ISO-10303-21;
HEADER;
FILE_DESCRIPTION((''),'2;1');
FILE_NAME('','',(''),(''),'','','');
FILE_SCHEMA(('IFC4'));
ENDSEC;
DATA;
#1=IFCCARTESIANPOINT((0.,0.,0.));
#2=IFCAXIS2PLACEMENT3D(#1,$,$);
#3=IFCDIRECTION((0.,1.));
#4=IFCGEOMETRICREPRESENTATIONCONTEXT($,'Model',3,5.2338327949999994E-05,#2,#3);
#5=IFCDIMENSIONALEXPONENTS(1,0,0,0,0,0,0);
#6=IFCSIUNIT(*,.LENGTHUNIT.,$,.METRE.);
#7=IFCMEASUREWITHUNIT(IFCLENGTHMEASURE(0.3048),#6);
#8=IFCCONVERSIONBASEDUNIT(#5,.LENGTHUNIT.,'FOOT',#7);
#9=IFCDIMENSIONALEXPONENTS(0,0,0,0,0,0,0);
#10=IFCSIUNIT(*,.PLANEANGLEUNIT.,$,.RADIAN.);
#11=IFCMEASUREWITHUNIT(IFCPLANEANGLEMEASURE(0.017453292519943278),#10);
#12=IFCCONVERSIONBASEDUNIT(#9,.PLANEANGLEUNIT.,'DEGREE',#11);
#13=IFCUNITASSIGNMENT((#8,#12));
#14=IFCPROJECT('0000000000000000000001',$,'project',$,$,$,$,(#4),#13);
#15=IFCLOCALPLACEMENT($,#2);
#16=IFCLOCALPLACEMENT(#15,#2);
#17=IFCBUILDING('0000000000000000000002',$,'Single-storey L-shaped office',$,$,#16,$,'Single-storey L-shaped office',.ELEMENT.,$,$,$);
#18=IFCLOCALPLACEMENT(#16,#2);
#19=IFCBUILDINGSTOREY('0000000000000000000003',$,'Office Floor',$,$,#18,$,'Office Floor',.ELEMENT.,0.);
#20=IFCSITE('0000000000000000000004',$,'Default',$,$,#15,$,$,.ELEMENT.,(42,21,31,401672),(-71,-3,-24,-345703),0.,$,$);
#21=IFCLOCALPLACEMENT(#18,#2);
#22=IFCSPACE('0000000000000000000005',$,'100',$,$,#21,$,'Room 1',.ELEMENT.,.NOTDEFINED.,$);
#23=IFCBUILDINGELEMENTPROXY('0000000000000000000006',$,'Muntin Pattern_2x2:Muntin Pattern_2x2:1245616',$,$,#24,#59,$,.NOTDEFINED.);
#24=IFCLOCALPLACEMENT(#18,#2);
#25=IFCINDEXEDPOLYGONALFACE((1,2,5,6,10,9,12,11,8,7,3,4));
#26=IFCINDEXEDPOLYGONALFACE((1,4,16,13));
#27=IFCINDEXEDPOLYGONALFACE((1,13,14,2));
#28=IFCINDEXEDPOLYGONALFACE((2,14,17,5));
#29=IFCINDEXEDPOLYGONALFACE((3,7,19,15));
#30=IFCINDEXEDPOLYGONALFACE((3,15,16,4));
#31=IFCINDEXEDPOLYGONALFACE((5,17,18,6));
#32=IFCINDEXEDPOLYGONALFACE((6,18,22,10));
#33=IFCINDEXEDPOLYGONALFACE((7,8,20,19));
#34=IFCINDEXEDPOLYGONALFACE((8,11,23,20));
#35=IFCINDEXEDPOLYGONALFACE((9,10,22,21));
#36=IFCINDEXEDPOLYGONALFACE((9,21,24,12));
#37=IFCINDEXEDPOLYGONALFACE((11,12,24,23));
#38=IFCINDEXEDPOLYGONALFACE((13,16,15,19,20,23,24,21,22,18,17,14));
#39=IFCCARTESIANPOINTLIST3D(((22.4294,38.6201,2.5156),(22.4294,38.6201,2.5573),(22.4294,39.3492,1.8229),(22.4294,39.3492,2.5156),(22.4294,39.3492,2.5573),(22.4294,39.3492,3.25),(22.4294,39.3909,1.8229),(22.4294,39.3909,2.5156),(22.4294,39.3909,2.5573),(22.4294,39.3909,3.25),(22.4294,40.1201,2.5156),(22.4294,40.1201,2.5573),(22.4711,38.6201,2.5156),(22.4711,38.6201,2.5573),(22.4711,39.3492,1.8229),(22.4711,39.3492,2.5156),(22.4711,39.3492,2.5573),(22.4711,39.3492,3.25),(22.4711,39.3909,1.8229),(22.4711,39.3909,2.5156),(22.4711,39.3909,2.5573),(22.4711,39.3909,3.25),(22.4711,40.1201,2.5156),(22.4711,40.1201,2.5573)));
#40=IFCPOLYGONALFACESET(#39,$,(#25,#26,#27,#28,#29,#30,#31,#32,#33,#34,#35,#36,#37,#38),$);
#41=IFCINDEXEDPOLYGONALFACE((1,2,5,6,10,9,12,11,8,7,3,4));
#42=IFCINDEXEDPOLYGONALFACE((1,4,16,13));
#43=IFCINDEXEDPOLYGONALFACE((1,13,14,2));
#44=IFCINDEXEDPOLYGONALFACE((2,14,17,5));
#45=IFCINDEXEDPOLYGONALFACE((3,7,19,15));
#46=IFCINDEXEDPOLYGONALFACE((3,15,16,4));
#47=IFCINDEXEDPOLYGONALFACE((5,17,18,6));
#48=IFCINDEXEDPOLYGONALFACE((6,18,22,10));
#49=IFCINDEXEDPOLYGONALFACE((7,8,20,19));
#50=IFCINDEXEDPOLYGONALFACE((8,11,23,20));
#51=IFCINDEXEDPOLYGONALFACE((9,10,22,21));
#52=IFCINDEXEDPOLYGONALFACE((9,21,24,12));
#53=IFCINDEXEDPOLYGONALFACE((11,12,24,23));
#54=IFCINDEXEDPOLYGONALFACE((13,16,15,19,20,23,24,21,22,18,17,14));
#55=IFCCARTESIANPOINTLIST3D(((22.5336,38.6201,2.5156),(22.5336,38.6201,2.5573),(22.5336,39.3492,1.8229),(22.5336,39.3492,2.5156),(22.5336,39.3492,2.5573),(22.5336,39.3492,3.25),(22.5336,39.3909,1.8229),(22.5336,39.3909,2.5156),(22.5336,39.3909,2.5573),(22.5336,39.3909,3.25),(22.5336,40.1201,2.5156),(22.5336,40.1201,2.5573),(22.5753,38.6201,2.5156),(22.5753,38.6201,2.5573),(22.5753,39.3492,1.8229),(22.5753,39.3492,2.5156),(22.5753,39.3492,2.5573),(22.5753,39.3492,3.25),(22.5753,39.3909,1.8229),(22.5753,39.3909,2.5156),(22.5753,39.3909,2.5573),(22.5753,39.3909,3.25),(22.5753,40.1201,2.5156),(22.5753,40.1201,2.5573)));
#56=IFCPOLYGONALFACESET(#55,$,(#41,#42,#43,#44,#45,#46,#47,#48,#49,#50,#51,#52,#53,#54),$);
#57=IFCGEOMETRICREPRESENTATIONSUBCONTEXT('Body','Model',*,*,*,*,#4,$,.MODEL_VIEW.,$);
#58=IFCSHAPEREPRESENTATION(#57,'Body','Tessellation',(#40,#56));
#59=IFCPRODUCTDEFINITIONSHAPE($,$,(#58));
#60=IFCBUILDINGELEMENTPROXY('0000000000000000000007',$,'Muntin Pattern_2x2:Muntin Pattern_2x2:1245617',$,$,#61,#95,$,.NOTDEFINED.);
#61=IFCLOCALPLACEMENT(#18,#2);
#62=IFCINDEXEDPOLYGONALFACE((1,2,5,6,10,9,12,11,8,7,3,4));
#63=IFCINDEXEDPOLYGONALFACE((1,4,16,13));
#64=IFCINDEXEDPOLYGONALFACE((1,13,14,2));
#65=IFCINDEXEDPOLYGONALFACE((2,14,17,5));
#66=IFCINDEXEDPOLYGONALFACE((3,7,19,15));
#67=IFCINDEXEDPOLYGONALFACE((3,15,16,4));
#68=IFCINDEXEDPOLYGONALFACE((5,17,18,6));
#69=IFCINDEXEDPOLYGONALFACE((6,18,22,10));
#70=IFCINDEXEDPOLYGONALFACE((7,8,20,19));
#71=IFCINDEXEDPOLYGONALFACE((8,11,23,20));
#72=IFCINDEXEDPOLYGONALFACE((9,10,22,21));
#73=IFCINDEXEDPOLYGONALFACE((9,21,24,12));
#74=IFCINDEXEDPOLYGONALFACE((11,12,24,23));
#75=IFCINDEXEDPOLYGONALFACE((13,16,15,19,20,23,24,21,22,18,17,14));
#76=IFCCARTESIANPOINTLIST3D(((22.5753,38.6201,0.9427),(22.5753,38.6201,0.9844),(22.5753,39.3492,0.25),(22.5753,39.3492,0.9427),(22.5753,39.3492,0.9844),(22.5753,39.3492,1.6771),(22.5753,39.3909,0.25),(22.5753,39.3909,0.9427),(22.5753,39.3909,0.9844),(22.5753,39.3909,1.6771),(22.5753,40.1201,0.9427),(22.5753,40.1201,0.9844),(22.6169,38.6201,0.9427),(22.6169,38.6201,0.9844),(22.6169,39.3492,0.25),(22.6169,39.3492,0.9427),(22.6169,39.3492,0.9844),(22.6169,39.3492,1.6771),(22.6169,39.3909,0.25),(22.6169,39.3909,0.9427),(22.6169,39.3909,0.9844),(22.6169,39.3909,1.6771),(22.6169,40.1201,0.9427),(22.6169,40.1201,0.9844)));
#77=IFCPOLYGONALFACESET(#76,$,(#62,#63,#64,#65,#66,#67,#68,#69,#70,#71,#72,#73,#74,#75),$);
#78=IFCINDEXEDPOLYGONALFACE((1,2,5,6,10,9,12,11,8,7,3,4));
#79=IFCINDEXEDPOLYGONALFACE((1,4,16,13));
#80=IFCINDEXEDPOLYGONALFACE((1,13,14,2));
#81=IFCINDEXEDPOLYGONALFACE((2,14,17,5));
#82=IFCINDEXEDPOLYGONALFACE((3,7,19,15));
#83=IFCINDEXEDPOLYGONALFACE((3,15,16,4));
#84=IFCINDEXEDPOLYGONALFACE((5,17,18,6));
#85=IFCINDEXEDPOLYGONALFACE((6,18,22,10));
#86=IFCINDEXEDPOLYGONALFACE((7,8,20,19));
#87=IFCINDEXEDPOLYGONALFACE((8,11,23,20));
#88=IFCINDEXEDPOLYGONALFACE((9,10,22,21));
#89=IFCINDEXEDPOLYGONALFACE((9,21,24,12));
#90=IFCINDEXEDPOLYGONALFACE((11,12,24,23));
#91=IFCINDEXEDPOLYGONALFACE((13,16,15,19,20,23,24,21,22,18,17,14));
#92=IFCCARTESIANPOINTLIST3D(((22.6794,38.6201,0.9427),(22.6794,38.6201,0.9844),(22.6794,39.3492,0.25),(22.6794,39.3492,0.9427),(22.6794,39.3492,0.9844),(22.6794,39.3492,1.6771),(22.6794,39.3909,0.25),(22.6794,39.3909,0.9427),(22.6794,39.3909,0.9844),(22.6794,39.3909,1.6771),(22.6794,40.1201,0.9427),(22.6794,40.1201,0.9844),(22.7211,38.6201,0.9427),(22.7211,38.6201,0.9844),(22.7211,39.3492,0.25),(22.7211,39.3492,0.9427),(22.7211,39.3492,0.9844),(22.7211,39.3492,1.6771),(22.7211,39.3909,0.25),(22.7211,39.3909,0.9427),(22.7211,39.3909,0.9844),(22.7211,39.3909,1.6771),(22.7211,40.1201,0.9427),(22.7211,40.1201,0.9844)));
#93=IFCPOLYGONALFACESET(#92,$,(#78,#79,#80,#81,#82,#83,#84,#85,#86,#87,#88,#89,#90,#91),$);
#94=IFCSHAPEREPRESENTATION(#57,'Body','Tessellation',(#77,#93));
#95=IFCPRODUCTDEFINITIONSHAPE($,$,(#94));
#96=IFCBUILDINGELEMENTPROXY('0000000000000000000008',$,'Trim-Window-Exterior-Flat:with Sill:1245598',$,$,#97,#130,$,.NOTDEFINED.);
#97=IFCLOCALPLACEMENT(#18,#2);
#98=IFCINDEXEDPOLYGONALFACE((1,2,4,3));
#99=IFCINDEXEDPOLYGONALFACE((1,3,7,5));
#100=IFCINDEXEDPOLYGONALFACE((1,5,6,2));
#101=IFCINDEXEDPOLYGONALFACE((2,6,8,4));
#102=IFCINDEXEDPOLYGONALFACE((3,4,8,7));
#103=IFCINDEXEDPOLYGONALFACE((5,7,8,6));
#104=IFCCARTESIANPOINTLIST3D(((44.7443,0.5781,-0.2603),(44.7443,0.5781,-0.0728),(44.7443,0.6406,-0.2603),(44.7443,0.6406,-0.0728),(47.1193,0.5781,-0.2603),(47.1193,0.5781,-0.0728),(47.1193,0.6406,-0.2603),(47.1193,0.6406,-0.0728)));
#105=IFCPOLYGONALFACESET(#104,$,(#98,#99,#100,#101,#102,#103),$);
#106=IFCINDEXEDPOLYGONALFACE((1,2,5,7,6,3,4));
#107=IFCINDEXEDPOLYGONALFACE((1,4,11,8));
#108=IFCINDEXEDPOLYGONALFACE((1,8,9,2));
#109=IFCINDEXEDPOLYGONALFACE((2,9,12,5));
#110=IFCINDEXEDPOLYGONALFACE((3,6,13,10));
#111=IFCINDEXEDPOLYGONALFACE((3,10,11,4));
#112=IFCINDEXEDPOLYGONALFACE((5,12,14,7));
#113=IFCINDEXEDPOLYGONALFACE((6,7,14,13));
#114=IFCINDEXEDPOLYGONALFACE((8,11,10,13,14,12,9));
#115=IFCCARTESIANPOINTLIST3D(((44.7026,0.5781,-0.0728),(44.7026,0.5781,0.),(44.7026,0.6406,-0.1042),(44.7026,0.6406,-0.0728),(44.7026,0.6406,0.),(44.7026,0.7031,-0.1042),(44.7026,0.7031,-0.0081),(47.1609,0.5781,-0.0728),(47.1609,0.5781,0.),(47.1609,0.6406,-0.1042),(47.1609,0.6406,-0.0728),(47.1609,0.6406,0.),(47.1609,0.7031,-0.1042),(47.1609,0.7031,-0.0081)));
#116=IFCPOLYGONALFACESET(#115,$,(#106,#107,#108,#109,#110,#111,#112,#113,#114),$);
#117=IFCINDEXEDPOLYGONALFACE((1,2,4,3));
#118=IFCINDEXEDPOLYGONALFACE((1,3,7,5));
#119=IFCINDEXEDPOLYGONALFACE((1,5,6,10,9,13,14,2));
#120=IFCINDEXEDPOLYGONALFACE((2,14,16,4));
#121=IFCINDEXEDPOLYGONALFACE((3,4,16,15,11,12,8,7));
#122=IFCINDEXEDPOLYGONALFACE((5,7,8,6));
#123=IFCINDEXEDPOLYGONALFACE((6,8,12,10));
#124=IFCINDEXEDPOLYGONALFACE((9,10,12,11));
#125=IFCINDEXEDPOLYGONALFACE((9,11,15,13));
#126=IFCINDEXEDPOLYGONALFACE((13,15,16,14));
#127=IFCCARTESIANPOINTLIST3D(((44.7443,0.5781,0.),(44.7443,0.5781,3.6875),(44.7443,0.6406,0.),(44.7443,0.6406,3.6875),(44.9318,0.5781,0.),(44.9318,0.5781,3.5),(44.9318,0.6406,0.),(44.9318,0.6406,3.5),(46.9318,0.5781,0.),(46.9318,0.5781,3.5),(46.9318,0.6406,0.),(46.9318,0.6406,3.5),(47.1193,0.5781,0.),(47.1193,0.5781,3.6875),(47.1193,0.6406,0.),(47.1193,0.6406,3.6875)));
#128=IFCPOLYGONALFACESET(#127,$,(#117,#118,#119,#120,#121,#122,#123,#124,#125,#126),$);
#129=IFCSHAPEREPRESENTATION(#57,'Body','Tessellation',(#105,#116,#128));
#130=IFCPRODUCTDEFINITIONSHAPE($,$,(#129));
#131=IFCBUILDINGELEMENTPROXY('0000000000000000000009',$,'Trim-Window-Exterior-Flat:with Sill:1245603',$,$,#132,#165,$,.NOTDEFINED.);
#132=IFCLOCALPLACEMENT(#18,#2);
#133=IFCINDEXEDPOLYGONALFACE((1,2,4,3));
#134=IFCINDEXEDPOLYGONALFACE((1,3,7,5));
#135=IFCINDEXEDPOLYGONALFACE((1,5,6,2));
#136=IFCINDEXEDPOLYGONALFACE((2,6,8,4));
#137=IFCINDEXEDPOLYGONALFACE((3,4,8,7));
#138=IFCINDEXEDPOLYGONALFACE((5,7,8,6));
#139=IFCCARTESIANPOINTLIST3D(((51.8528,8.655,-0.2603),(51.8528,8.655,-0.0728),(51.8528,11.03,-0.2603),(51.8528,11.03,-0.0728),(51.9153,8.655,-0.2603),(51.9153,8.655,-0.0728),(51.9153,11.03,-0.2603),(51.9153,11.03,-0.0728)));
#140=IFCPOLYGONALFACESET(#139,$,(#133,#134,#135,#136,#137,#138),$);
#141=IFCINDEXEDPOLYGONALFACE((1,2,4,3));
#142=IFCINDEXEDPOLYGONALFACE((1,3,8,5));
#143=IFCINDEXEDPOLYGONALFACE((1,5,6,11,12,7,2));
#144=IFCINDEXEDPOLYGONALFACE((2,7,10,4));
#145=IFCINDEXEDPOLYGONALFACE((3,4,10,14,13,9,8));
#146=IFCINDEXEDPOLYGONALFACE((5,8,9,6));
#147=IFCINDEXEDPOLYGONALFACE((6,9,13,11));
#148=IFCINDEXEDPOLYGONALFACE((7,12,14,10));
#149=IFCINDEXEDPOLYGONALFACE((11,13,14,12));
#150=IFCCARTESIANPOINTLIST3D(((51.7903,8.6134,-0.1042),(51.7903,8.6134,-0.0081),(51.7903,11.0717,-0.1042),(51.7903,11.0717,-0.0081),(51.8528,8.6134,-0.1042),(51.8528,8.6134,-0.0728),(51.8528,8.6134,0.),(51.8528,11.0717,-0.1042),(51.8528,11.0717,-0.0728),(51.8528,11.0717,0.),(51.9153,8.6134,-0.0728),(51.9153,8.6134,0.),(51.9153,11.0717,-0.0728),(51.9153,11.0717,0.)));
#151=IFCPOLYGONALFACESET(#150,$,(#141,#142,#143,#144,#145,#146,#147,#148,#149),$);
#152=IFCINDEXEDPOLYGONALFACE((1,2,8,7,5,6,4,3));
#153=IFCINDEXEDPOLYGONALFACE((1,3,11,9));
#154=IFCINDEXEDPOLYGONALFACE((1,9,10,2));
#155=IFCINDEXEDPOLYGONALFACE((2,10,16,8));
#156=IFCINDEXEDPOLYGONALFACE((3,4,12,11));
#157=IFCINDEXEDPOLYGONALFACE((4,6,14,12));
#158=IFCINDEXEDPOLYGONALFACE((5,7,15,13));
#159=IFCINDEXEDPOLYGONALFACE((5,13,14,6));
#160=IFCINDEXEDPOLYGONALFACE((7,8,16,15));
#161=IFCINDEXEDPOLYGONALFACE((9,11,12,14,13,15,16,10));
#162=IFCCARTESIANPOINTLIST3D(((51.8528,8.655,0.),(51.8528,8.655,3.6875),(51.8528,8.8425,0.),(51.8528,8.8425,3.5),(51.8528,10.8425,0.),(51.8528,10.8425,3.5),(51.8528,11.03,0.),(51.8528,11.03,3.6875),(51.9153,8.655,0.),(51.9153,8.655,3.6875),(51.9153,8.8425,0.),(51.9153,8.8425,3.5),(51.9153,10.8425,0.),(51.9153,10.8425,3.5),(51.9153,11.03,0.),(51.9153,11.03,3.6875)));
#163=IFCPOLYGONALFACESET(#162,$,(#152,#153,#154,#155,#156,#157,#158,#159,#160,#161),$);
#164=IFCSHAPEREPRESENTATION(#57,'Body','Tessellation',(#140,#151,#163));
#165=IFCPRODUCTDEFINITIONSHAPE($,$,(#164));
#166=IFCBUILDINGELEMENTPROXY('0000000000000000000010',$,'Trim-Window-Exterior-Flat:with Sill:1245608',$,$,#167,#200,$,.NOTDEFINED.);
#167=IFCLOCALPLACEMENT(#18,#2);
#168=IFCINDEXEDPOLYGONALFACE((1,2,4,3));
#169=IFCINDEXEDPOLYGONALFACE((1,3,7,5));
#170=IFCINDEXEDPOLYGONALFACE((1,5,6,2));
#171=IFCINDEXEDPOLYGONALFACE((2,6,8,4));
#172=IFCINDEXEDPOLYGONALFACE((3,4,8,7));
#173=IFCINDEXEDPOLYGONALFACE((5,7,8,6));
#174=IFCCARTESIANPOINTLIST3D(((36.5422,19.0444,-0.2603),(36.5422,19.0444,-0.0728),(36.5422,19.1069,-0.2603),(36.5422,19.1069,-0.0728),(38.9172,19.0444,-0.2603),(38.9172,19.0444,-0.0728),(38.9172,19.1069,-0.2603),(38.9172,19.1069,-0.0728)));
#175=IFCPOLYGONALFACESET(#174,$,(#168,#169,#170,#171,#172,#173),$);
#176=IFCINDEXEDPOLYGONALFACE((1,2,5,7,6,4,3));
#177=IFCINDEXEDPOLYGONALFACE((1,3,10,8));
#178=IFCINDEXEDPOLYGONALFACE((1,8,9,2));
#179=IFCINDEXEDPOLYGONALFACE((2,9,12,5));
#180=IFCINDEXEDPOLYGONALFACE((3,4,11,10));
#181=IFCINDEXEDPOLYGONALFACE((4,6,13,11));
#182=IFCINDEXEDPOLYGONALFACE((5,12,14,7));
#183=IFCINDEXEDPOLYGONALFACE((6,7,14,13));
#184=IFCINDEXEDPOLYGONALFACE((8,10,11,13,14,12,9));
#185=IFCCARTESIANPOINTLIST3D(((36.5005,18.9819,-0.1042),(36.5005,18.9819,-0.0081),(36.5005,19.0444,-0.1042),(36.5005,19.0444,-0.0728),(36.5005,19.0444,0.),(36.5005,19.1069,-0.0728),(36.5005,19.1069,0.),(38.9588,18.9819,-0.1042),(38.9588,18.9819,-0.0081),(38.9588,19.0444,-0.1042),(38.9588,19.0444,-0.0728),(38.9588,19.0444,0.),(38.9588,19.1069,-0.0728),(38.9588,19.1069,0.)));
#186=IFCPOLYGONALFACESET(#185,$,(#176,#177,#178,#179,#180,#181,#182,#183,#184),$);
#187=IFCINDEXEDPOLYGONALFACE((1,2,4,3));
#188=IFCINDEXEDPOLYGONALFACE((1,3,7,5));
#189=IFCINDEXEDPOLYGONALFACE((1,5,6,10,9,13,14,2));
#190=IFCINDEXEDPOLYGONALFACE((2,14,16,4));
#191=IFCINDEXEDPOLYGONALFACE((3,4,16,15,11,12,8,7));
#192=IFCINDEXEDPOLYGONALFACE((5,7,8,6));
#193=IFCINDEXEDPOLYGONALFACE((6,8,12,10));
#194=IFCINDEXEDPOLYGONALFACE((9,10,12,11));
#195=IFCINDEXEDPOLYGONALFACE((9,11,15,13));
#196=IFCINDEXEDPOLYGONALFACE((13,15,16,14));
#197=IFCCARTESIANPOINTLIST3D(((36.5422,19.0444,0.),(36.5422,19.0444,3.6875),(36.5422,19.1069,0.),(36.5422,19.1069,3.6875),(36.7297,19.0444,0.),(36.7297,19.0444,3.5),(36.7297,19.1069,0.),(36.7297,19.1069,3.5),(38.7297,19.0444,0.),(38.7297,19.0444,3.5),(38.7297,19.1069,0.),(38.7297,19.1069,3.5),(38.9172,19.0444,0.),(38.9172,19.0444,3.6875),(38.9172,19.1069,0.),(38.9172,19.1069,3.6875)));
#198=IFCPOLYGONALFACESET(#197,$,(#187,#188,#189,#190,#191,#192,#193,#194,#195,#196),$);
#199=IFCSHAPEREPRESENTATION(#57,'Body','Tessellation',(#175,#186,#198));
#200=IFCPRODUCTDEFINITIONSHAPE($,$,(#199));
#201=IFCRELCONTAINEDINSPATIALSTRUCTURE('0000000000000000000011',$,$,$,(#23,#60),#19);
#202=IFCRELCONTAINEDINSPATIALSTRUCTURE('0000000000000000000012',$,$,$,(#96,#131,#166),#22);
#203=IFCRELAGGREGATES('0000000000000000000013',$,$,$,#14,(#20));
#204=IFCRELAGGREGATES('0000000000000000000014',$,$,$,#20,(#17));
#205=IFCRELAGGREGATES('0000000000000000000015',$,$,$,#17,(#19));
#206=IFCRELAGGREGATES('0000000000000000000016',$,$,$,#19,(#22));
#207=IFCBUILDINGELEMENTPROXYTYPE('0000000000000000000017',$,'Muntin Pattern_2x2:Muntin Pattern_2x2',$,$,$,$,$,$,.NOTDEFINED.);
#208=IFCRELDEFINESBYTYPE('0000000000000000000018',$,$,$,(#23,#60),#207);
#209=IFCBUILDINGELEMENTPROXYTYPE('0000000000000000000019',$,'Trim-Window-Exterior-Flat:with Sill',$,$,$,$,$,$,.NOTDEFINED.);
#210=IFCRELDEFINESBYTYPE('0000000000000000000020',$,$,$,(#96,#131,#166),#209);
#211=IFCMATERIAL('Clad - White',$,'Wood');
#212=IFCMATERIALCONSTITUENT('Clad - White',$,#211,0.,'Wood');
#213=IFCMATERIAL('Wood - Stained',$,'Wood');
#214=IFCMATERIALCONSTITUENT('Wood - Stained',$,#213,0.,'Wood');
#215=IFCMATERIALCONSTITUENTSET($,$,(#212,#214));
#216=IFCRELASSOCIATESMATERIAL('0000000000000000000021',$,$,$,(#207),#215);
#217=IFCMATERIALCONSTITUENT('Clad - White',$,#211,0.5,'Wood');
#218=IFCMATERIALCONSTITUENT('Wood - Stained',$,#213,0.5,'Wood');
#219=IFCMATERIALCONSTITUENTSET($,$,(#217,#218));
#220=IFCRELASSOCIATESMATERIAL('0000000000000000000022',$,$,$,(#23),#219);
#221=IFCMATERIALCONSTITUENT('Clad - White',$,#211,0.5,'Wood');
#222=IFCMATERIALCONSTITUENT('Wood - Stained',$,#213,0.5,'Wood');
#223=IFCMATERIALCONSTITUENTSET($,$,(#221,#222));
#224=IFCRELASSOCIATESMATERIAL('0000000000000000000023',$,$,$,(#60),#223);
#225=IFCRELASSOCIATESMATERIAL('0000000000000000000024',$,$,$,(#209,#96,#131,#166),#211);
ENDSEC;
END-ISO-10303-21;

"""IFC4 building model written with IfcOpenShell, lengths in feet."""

from ifc_helpers import new_model, entity, si_unit, converted_unit, direction, frame, origin, place, context, subcontext, project, spatial, indexed_curve, outline, extrude, source, transform, mapped, material, constituent, constituent_set, type_object, type_shapes, element, save


model = new_model("IFC4")

# Units and contexts
model_context = context("Model", 3, precision=5.2338327949999994e-05, world=origin(), true_north=direction((0.0, 1.0)))
body_context = subcontext(model_context, "Body", "Model", "MODEL_VIEW")
ifc_project = project(units=[converted_unit("LENGTHUNIT", "FOOT", entity("IfcLengthMeasure", 0.3048), si_unit("LENGTHUNIT", "METRE"), dimensions=[1, 0, 0, 0, 0, 0, 0]), converted_unit("PLANEANGLEUNIT", "DEGREE", entity("IfcPlaneAngleMeasure", 0.017453292519943278), si_unit("PLANEANGLEUNIT", "RADIAN"), dimensions=[0, 0, 0, 0, 0, 0, 0])], contexts=[model_context])

# Site, building, storey
site_placement = place(None, origin())
site = spatial("IfcSite", under=ifc_project, at=site_placement, Name="Default", CompositionType="ELEMENT", RefLatitude=(42, 21, 31, 401672), RefLongitude=(-71, -3, -24, -345703), RefElevation=0.0)
building_placement = place(site_placement, origin())
building = spatial("IfcBuilding", under=site, at=building_placement, Name="Single-storey L-shaped office", LongName="Single-storey L-shaped office", CompositionType="ELEMENT")
storey_placement = place(building_placement, origin())
storey = spatial("IfcBuildingStorey", under=building, at=storey_placement, Name="Office Floor", LongName="Office Floor", CompositionType="ELEMENT", Elevation=0.0)

# Shared definitions
ifc_material_1 = material(Name="Wood - Stained", Category="Wood")

# Building element proxies
ifc_material_2 = material(Name="Clad - White", Category="Wood")
ifc_constituent_1 = constituent(ifc_material_2, Name="Clad - White", Category="Wood", fraction=0.0)
ifc_constituent_2 = constituent(ifc_material_1, Name="Wood - Stained", Category="Wood", fraction=0.0)
ifc_constituent_set_1 = constituent_set(constituents=[ifc_constituent_1, ifc_constituent_2])
building_element_proxy_type_1 = type_object("IfcBuildingElementProxyType", Name="Muntin Pattern_2x2:Muntin Pattern_2x2", PredefinedType="NOTDEFINED", material=ifc_constituent_set_1)
shared_shape_1 = source(origin(), body_context, "Body", "SweptSolid", [
    extrude(outline(indexed_curve([(0.0208, -0.0208), (0.7135, -0.0208), (0.7135, 0.0208), (0.0208, 0.0208), (0.0208, 0.75), (-0.0208, 0.75), (-0.0208, 0.0208), (-0.7135, 0.0208), (-0.7135, -0.0208), (-0.0208, -0.0208), (-0.0208, -0.75), (0.0208, -0.75), (0.0208, -0.0208)], self_intersect=False)), frame((0.0, 0.0312, 0.7135), z_axis=(0.0, 1.0, 0.0), x_axis=(0.0, 0.0, 1.0)), (0.0, 0.0, 1.0), 0.0417),
    extrude(outline(indexed_curve([(0.0208, -0.0208), (0.7135, -0.0208), (0.7135, 0.0208), (0.0208, 0.0208), (0.0208, 0.75), (-0.0208, 0.75), (-0.0208, 0.0208), (-0.7135, 0.0208), (-0.7135, -0.0208), (-0.0208, -0.0208), (-0.0208, -0.75), (0.0208, -0.75), (0.0208, -0.0208)], self_intersect=False)), frame((0.0, -0.0729, 0.7135), z_axis=(0.0, 1.0, 0.0), x_axis=(0.0, 0.0, 1.0)), (0.0, 0.0, 1.0), 0.0417),
])
type_shapes(building_element_proxy_type_1, [shared_shape_1])
ifc_constituent_3 = constituent(ifc_material_2, Name="Clad - White", Category="Wood", fraction=0.5)
ifc_constituent_4 = constituent(ifc_material_1, Name="Wood - Stained", Category="Wood", fraction=0.5)
ifc_constituent_set_2 = constituent_set(constituents=[ifc_constituent_3, ifc_constituent_4])
proxy_1_placement = place(storey_placement, frame((22.5023, 39.3701, 1.8229), z_axis=(0.0, 0.0, 1.0), x_axis=(0.0, 1.0, 0.0)))
element("IfcBuildingElementProxy", 1, at=proxy_1_placement, inside=storey, type_object=building_element_proxy_type_1, material=ifc_constituent_set_2, Name="Muntin Pattern_2x2:Muntin Pattern_2x2:1245616", PredefinedType="NOTDEFINED", context=body_context, shape_type="MappedRepresentation", body=[
    mapped(shared_shape_1, transform((0.0, 0.0, 0.0), scale=1.0)),
])
ifc_constituent_5 = constituent(ifc_material_2, Name="Clad - White", Category="Wood", fraction=0.5)
ifc_constituent_6 = constituent(ifc_material_1, Name="Wood - Stained", Category="Wood", fraction=0.5)
ifc_constituent_set_3 = constituent_set(constituents=[ifc_constituent_5, ifc_constituent_6])
proxy_2_placement = place(storey_placement, frame((22.6482, 39.3701, 0.25), z_axis=(0.0, 0.0, 1.0), x_axis=(0.0, 1.0, 0.0)))
element("IfcBuildingElementProxy", 2, at=proxy_2_placement, inside=storey, type_object=building_element_proxy_type_1, material=ifc_constituent_set_3, Name="Muntin Pattern_2x2:Muntin Pattern_2x2:1245617", PredefinedType="NOTDEFINED", context=body_context, shape_type="MappedRepresentation", body=[
    mapped(shared_shape_1, transform((0.0, 0.0, 0.0), scale=1.0)),
])

# Shared definitions
space_1_placement = place(storey_placement, origin())
space_1 = spatial("IfcSpace", under=storey, at=space_1_placement, Name="100", LongName="Room 1", CompositionType="ELEMENT", PredefinedType="NOTDEFINED")

# Building element proxies
building_element_proxy_type_2 = type_object("IfcBuildingElementProxyType", Name="Trim-Window-Exterior-Flat:with Sill", PredefinedType="NOTDEFINED", material=ifc_material_2)
shared_shape_2 = source(origin(), body_context, "Body", "SweptSolid", [
    extrude(outline(indexed_curve([(-1.1875, -0.0938), (1.1875, -0.0938), (1.1875, 0.0938), (-1.1875, 0.0938), (-1.1875, -0.0938)], self_intersect=False)), frame((0.0, -3.6665, 0.0), z_axis=(0.0, 0.0, 1.0), x_axis=(-1.0, 0.0, 0.0)), (0.0, 0.0, 1.0), 0.0625),
    extrude(outline(indexed_curve([(-0.0625, -0.0525), (0.0, -0.0525), (0.0, -0.0211), (0.0625, -0.0211), (0.0625, 0.0517), (0.0, 0.0517), (-0.0625, 0.0436), (-0.0625, -0.0525)], self_intersect=False)), frame((-1.2292, -3.5517, 0.0625), z_axis=(1.0, 0.0, 0.0), x_axis=(0.0, 0.0, -1.0)), (0.0, 0.0, 1.0), 2.4583),
    extrude(outline(indexed_curve([(-1.8906, -1.1875), (1.7969, -1.1875), (1.7969, -1.0), (-1.7031, -1.0), (-1.7031, 1.0), (1.7969, 1.0), (1.7969, 1.1875), (-1.8906, 1.1875), (-1.8906, -1.1875)], self_intersect=False)), frame((0.0, -1.7031, 0.0), z_axis=(0.0, 0.0, 1.0), x_axis=(0.0, -1.0, 0.0)), (0.0, 0.0, 1.0), 0.0625),
])
type_shapes(building_element_proxy_type_2, [shared_shape_2])
for number, where, z_axis, x_axis, name in (
    (3, (45.9318, 0.5781, 3.5), (0.0, 1.0, 0.0), (-1.0, 0.0, 0.0), "Trim-Window-Exterior-Flat:with Sill:1245598"),
    (4, (51.9153, 9.8425, 3.5), (-1.0, 0.0, 0.0), (0.0, -1.0, 0.0), "Trim-Window-Exterior-Flat:with Sill:1245603"),
    (5, (37.7297, 19.1069, 3.5), (0.0, -1.0, 0.0), (1.0, 0.0, 0.0), "Trim-Window-Exterior-Flat:with Sill:1245608"),
):
    element("IfcBuildingElementProxy", number, at=place(space_1_placement, frame(where, z_axis=z_axis, x_axis=x_axis)), inside=space_1, type_object=building_element_proxy_type_2, material=ifc_material_2, Name=name, PredefinedType="NOTDEFINED", context=body_context, shape_type="MappedRepresentation", body=[
        mapped(shared_shape_2, transform((0.0, 0.0, 0.0), scale=1.0)),
    ])

save(model, "model.ifc")
